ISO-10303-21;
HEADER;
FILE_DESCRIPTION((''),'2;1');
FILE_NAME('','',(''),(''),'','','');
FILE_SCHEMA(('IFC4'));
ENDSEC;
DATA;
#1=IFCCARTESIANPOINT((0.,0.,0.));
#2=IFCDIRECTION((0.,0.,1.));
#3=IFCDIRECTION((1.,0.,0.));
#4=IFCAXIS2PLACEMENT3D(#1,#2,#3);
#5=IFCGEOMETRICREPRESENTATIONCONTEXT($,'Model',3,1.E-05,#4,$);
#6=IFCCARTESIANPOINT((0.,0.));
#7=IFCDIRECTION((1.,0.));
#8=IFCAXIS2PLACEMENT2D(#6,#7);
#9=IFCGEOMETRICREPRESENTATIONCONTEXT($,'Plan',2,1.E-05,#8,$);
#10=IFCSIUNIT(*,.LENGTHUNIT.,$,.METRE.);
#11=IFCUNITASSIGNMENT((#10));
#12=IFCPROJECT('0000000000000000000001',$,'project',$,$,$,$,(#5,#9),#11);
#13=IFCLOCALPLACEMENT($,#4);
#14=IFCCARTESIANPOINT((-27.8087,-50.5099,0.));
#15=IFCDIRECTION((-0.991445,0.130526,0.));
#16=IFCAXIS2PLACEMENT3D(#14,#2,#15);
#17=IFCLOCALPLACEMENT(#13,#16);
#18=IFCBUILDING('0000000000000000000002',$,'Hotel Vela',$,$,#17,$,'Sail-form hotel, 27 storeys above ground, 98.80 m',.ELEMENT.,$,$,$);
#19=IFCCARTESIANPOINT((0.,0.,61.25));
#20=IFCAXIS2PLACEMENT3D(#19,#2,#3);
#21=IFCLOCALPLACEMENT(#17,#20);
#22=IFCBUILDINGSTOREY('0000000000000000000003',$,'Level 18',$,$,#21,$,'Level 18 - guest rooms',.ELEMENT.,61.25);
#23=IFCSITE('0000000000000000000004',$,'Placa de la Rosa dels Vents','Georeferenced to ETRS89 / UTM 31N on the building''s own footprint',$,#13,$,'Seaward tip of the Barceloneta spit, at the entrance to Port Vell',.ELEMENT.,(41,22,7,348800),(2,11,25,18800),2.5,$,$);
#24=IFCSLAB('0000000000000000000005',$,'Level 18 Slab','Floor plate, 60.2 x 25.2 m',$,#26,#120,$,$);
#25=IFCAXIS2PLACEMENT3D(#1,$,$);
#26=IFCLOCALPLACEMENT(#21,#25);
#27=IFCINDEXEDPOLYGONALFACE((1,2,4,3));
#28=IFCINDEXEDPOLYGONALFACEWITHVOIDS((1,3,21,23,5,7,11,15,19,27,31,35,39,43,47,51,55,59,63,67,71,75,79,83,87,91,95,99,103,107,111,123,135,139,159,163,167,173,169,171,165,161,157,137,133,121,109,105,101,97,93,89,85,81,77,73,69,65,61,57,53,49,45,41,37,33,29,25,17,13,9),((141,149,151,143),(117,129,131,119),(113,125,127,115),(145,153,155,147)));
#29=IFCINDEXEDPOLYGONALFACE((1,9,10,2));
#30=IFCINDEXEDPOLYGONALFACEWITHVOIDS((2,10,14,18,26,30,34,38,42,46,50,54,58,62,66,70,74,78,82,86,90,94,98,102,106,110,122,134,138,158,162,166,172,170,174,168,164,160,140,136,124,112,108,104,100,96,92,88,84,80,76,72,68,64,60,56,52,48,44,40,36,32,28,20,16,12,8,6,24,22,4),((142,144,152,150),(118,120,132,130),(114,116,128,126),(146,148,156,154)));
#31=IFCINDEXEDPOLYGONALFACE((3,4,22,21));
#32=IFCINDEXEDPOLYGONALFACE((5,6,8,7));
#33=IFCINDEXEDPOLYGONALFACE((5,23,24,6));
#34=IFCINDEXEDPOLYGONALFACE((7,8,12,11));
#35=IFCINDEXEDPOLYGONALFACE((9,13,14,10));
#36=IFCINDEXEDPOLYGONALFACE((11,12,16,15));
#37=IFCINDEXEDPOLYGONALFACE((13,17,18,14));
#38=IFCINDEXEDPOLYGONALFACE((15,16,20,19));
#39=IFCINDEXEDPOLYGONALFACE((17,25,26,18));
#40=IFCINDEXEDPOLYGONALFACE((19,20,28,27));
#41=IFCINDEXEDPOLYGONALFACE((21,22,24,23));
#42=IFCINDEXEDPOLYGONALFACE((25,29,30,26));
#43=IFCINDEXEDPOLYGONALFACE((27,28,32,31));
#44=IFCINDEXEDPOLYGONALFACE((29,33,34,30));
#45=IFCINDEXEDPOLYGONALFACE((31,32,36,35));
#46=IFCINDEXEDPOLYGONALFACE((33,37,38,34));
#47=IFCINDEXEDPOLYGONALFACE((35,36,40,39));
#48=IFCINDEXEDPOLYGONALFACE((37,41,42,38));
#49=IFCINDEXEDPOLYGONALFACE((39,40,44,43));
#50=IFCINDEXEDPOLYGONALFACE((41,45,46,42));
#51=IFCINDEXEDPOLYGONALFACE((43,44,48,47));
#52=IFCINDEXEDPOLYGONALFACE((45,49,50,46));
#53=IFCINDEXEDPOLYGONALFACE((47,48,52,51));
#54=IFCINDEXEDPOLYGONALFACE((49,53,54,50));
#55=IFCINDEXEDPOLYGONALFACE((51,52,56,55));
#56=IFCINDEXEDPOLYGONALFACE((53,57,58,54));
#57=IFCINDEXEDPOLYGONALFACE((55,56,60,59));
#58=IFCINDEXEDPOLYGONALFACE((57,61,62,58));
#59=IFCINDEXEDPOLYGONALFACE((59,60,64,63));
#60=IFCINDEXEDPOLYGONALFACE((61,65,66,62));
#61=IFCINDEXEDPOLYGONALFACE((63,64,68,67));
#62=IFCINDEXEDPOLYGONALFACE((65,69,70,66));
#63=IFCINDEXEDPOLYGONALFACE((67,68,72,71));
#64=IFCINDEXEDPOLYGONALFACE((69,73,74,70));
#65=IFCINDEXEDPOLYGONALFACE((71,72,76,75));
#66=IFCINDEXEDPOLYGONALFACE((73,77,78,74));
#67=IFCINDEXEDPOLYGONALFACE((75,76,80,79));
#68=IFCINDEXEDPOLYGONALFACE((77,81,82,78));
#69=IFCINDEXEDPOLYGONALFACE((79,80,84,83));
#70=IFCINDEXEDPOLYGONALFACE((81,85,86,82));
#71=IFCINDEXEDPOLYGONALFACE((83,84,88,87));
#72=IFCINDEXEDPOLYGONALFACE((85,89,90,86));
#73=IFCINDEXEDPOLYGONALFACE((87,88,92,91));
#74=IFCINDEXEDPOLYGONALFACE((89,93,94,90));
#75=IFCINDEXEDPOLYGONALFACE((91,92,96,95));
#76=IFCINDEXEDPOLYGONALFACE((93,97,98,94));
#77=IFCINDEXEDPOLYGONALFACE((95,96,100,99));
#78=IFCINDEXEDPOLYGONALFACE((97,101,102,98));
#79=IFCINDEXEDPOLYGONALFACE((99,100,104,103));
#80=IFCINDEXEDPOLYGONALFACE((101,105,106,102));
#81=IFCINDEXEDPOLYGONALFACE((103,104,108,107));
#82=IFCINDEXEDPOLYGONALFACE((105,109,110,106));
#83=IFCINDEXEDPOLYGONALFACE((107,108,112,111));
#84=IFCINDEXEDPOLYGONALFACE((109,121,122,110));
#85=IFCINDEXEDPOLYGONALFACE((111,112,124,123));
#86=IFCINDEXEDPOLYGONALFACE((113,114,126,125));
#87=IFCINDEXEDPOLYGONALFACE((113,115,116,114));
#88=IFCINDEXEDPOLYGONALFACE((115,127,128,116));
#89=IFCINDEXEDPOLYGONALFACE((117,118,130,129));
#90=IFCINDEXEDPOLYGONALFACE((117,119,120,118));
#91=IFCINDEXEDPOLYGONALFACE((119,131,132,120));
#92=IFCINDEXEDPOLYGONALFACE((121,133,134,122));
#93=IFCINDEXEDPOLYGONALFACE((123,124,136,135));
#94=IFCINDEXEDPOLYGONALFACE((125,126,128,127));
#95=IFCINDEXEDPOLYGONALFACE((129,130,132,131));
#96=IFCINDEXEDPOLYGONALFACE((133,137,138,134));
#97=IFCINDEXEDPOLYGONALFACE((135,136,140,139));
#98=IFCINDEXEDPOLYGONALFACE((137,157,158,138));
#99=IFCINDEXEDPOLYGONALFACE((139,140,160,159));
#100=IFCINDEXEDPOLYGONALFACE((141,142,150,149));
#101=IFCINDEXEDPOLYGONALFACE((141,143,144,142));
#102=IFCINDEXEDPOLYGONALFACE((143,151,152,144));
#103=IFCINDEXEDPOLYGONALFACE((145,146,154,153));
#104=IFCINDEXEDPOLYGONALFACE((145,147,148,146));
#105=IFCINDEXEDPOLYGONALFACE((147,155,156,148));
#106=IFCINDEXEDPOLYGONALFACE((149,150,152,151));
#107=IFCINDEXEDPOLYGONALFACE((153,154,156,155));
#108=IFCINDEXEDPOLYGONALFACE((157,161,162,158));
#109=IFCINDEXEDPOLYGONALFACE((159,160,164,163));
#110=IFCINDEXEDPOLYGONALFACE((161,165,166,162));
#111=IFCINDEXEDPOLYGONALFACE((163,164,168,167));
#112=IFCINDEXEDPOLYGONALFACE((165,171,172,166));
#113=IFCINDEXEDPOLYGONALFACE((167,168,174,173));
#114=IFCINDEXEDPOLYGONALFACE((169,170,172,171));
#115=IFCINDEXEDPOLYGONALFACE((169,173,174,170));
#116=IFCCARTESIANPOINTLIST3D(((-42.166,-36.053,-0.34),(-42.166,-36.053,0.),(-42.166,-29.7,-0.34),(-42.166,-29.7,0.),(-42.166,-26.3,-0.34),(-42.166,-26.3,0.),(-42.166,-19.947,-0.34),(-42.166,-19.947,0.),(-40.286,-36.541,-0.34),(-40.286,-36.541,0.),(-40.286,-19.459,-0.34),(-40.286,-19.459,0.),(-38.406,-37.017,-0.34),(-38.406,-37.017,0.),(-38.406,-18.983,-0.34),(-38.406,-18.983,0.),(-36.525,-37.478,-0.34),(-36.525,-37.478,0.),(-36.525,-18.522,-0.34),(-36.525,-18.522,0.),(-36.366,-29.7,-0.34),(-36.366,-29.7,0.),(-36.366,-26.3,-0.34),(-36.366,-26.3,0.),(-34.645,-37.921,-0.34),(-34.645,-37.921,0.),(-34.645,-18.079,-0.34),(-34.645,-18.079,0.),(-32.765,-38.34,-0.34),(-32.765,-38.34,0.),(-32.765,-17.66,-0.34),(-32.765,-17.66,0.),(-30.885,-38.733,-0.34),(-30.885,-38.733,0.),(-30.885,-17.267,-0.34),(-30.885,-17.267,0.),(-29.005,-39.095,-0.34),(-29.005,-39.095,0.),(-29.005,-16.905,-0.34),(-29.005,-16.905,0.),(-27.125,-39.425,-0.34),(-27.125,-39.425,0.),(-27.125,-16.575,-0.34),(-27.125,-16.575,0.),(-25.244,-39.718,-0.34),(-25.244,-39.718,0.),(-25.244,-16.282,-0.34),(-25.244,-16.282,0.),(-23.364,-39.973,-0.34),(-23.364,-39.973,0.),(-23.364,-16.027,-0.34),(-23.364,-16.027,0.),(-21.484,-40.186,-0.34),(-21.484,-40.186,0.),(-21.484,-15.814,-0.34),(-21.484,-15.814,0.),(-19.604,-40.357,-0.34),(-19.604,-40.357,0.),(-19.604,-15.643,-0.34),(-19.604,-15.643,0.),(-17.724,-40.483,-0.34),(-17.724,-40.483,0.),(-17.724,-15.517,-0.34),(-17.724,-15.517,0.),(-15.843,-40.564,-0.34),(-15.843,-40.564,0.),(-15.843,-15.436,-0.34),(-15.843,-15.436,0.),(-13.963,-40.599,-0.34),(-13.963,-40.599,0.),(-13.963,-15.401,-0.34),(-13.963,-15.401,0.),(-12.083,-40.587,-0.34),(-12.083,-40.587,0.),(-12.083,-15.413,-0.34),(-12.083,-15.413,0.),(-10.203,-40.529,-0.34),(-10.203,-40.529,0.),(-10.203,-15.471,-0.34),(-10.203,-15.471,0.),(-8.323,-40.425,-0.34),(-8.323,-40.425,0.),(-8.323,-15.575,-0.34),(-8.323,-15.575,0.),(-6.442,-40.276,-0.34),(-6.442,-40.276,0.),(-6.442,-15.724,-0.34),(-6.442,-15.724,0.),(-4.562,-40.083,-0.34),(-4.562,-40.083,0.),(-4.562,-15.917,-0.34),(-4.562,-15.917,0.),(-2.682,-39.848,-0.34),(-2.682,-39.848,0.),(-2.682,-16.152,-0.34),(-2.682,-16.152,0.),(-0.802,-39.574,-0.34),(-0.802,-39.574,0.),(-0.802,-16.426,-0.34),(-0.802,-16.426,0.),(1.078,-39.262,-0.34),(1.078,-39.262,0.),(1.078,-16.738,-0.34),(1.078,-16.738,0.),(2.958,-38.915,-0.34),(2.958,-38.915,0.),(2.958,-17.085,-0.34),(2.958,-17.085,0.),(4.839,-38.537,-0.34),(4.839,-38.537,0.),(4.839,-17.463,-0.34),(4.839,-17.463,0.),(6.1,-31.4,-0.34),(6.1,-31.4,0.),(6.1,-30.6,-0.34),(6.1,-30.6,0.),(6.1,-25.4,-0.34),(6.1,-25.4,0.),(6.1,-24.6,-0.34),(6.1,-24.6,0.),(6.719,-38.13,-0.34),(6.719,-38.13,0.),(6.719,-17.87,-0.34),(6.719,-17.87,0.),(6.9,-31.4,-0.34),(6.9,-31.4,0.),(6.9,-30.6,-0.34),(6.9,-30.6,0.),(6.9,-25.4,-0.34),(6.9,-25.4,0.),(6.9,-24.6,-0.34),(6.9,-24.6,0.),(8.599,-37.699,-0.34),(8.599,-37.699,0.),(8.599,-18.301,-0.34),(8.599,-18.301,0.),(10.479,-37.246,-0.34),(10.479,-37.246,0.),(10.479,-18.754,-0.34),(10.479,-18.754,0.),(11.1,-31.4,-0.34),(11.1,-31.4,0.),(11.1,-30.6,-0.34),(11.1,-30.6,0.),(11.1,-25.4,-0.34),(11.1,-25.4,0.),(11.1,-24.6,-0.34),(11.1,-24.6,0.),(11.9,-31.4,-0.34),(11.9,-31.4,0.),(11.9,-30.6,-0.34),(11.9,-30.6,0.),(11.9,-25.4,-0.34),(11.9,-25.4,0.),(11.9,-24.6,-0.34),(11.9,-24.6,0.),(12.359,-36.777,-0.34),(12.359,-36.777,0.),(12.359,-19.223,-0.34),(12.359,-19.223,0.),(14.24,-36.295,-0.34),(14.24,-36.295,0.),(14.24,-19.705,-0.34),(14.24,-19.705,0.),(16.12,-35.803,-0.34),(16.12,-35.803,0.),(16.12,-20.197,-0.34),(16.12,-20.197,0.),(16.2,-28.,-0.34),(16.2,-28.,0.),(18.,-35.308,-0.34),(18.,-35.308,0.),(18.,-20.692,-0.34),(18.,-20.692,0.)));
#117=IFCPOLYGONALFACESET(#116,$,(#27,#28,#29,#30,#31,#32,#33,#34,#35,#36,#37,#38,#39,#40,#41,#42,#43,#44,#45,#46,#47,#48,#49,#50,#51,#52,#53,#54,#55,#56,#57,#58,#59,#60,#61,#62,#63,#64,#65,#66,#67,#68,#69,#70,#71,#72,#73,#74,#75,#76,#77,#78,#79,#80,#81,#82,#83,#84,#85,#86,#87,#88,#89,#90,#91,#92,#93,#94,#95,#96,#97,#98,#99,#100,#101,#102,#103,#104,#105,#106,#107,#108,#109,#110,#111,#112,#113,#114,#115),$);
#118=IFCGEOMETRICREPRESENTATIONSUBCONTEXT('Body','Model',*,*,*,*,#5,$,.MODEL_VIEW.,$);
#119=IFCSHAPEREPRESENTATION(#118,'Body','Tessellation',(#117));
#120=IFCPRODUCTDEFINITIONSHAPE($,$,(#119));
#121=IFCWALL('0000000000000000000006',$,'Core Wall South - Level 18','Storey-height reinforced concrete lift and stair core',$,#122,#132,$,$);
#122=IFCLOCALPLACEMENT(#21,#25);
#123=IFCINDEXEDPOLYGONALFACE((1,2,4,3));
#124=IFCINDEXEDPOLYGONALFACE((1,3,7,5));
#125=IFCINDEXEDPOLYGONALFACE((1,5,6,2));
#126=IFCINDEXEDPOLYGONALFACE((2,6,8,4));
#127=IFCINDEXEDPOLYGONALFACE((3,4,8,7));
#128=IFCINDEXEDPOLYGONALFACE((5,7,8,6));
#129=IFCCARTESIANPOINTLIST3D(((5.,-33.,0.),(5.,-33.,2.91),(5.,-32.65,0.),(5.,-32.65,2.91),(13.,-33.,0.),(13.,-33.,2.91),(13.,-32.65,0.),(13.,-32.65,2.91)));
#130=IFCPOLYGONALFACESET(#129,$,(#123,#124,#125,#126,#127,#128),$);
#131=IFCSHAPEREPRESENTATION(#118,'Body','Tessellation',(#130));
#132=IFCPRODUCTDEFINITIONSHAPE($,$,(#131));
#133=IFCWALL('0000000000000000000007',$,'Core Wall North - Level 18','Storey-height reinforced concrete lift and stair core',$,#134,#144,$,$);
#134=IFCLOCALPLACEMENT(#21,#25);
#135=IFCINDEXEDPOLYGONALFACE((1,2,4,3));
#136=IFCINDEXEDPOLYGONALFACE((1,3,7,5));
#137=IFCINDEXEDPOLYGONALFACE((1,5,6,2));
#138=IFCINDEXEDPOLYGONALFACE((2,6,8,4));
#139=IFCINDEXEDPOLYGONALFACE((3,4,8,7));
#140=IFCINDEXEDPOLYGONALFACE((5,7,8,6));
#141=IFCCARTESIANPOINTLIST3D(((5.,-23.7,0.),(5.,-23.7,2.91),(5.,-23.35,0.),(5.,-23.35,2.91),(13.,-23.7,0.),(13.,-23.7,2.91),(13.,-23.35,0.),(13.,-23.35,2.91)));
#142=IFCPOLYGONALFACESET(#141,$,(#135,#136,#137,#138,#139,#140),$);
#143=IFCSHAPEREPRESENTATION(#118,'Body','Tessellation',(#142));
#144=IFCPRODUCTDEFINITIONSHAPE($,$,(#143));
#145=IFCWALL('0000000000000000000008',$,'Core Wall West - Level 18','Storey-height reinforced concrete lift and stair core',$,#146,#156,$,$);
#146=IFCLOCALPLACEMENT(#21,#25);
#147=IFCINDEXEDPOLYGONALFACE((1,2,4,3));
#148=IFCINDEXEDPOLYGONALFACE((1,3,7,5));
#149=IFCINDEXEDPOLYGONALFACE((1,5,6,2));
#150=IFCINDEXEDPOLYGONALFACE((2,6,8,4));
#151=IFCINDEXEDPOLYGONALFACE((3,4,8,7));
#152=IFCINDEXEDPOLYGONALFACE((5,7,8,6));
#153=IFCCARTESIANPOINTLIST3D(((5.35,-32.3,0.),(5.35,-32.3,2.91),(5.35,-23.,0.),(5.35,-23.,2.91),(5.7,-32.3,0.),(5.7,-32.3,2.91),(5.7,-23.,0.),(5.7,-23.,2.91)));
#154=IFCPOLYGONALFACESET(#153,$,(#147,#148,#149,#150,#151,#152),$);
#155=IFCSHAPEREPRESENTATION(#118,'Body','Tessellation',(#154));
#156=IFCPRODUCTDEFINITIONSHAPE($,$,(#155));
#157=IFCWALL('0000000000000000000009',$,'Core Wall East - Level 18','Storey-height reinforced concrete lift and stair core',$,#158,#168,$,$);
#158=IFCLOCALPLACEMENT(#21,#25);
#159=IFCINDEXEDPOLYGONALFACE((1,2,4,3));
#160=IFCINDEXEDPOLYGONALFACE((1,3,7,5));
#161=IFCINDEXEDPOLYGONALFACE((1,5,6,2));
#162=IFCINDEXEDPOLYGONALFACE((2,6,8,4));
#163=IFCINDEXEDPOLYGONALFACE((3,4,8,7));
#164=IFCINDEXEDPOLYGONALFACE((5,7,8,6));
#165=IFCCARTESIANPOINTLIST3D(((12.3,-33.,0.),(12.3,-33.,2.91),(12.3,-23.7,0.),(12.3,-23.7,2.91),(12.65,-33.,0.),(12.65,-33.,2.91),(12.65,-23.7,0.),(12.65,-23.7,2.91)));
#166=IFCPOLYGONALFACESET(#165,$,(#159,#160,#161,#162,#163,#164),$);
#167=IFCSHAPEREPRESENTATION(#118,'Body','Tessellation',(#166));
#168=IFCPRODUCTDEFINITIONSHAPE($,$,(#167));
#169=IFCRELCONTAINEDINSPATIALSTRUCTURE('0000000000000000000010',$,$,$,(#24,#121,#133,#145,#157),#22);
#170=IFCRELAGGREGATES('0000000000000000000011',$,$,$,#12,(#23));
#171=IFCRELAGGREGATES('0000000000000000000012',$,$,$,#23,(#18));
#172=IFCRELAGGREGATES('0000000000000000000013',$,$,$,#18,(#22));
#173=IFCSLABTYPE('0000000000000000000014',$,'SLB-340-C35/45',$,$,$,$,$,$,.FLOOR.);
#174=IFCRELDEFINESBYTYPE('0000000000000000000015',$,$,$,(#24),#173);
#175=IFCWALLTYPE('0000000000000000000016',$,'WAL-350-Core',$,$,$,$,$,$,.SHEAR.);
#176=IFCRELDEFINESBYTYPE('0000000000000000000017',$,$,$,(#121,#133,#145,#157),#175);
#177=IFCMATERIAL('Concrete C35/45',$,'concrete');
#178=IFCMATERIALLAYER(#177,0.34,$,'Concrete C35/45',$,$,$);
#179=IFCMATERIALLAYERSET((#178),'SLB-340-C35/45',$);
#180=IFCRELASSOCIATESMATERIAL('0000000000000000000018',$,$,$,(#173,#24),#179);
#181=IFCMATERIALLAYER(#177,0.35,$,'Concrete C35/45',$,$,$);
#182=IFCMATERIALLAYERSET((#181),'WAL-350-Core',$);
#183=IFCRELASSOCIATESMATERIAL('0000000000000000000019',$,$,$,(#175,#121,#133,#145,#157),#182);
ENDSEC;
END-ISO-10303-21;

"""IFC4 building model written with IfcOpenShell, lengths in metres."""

from ifc_helpers import new_model, si_unit, frame, origin_with_axes, origin_2d_with_axis, place, context, subcontext, project, spatial, line, indexed_curve, outline, extrude, material, layer, layer_set, layer_usage, type_object, element, save


model = new_model("IFC4")

# Units and contexts
model_context = context("Model", 3, precision=1e-05, world=origin_with_axes())
plan_context = context("Plan", 2, precision=1e-05, world=origin_2d_with_axis())
body_context = subcontext(model_context, "Body", "Model", "MODEL_VIEW")
ifc_project = project(units=[si_unit("LENGTHUNIT", "METRE")], contexts=[model_context, plan_context])

# Site, building, storey
site_placement = place(None, origin_with_axes())
site = spatial("IfcSite", under=ifc_project, at=site_placement, Name="Placa de la Rosa dels Vents", Description="Georeferenced to ETRS89 / UTM 31N on the building's own footprint", LongName="Seaward tip of the Barceloneta spit, at the entrance to Port Vell", CompositionType="ELEMENT", RefLatitude=(41, 22, 7, 348800), RefLongitude=(2, 11, 25, 18800), RefElevation=2.5)
building_placement = place(site_placement, frame((-27.8087, -50.5099, 0.0), z_axis=(0.0, 0.0, 1.0), x_axis=(-0.991445, 0.130526, 0.0)))
building = spatial("IfcBuilding", under=site, at=building_placement, Name="Hotel Vela", LongName="Sail-form hotel, 27 storeys above ground, 98.80 m", CompositionType="ELEMENT")
storey_placement = place(building_placement, frame((0.0, 0.0, 61.25), z_axis=(0.0, 0.0, 1.0), x_axis=(1.0, 0.0, 0.0)))
storey = spatial("IfcBuildingStorey", under=building, at=storey_placement, Name="Level 18", LongName="Level 18 - guest rooms", CompositionType="ELEMENT", Elevation=61.25)

# Shared definitions
ifc_material = material(Name="Concrete C35/45", Category="concrete")

# Slab, openings
ifc_layer_1 = layer(ifc_material, 0.34, Name="Concrete C35/45")
ifc_layer_set_1 = layer_set([ifc_layer_1], Name="SLB-340-C35/45")
ifc_layer_usage_1 = layer_usage(ifc_layer_set_1, "AXIS3", "POSITIVE", 0.0)
slab_type = type_object("IfcSlabType", Name="SLB-340-C35/45", PredefinedType="FLOOR", material=ifc_layer_set_1)
slab_placement = place(storey_placement, frame((0.0, 0.0, -0.34), z_axis=(0.0, 0.0, 1.0), x_axis=(1.0, 0.0, 0.0)))
slab = element("IfcSlab", 1, at=slab_placement, inside=storey, type_object=slab_type, material=ifc_layer_usage_1, Name="Level 18 Slab", Description="Floor plate, 60.2 x 25.2 m", context=body_context, shape_type="SweptSolid", body=[
    extrude(outline(indexed_curve([(-42.166, -36.053), (-40.286, -36.541), (-38.406, -37.017), (-36.525, -37.478), (-34.645, -37.921), (-32.765, -38.34), (-30.885, -38.733), (-29.005, -39.095), (-27.125, -39.425), (-25.244, -39.718), (-23.364, -39.973), (-21.484, -40.186), (-19.604, -40.357), (-17.724, -40.483), (-15.843, -40.564), (-13.963, -40.599), (-12.083, -40.587), (-10.203, -40.529), (-8.323, -40.425), (-6.442, -40.276), (-4.562, -40.083), (-2.682, -39.848), (-0.802, -39.574), (1.078, -39.262), (2.958, -38.915), (4.839, -38.537), (6.719, -38.13), (8.599, -37.699), (10.479, -37.246), (12.359, -36.777), (14.24, -36.295), (16.12, -35.803), (18.0, -35.308), (16.2, -28.0), (18.0, -20.692), (16.12, -20.197), (14.24, -19.705), (12.359, -19.223), (10.479, -18.754), (8.599, -18.301), (6.719, -17.87), (4.839, -17.463), (2.958, -17.085), (1.078, -16.738), (-0.802, -16.426), (-2.682, -16.152), (-4.562, -15.917), (-6.442, -15.724), (-8.323, -15.575), (-10.203, -15.471), (-12.083, -15.413), (-13.963, -15.401), (-15.843, -15.436), (-17.724, -15.517), (-19.604, -15.643), (-21.484, -15.814), (-23.364, -16.027), (-25.244, -16.282), (-27.125, -16.575), (-29.005, -16.905), (-30.885, -17.267), (-32.765, -17.66), (-34.645, -18.079), (-36.525, -18.522), (-38.406, -18.983), (-40.286, -19.459), (-42.166, -19.947), (-42.166, -26.3), (-36.366, -26.3), (-36.366, -29.7), (-42.166, -29.7)], segments=[line(1, 2, 3, 4, 5, 6, 7, 8, 9, 10, 11, 12, 13, 14, 15, 16, 17, 18, 19, 20, 21, 22, 23, 24, 25, 26, 27, 28, 29, 30, 31, 32, 33, 34, 35, 36, 37, 38, 39, 40, 41, 42, 43, 44, 45, 46, 47, 48, 49, 50, 51, 52, 53, 54, 55, 56, 57, 58, 59, 60, 61, 62, 63, 64, 65, 66, 67, 68, 69, 70, 71, 1)])), origin_with_axes(), (0.0, 0.0, 1.0), 0.34),
])
opening_1_placement = place(slab_placement, frame((6.1, -31.4, -0.05), z_axis=(0.0, 0.0, 1.0), x_axis=(1.0, 0.0, 0.0)))
element("IfcOpeningElement", 2, at=opening_1_placement, cuts=slab, PredefinedType="OPENING", context=body_context, shape_type="SweptSolid", body=[
    extrude(outline(indexed_curve([(0.0, 0.0), (0.8, 0.0), (0.8, 0.8), (0.0, 0.8)], segments=[line(1, 2, 3, 4, 1)])), origin_with_axes(), (0.0, 0.0, 1.0), 0.44),
])
opening_2_placement = place(slab_placement, frame((6.1, -25.4, -0.05), z_axis=(0.0, 0.0, 1.0), x_axis=(1.0, 0.0, 0.0)))
element("IfcOpeningElement", 3, at=opening_2_placement, cuts=slab, PredefinedType="OPENING", context=body_context, shape_type="SweptSolid", body=[
    extrude(outline(indexed_curve([(0.0, 0.0), (0.8, 0.0), (0.8, 0.8), (0.0, 0.8)], segments=[line(1, 2, 3, 4, 1)])), origin_with_axes(), (0.0, 0.0, 1.0), 0.44),
])
opening_3_placement = place(slab_placement, frame((11.1, -31.4, -0.05), z_axis=(0.0, 0.0, 1.0), x_axis=(1.0, 0.0, 0.0)))
element("IfcOpeningElement", 4, at=opening_3_placement, cuts=slab, PredefinedType="OPENING", context=body_context, shape_type="SweptSolid", body=[
    extrude(outline(indexed_curve([(0.0, 0.0), (0.8, 0.0), (0.8, 0.8), (0.0, 0.8)], segments=[line(1, 2, 3, 4, 1)])), origin_with_axes(), (0.0, 0.0, 1.0), 0.44),
])
opening_4_placement = place(slab_placement, frame((11.1, -25.4, -0.05), z_axis=(0.0, 0.0, 1.0), x_axis=(1.0, 0.0, 0.0)))
element("IfcOpeningElement", 5, at=opening_4_placement, cuts=slab, PredefinedType="OPENING", context=body_context, shape_type="SweptSolid", body=[
    extrude(outline(indexed_curve([(0.0, 0.0), (0.8, 0.0), (0.8, 0.8), (0.0, 0.8)], segments=[line(1, 2, 3, 4, 1)])), origin_with_axes(), (0.0, 0.0, 1.0), 0.44),
])

# Walls
ifc_layer_2 = layer(ifc_material, 0.35, Name="Concrete C35/45")
ifc_layer_set_2 = layer_set([ifc_layer_2], Name="WAL-350-Core")
ifc_layer_usage_2 = layer_usage(ifc_layer_set_2, "AXIS2", "POSITIVE", 0.0)
wall_type = type_object("IfcWallType", Name="WAL-350-Core", PredefinedType="SHEAR", material=ifc_layer_set_2)
wall_1_placement = place(storey_placement, frame((5.0, -33.0, 0.0), z_axis=(0.0, 0.0, 1.0), x_axis=(1.0, 0.0, 0.0)))
element("IfcWall", 6, at=wall_1_placement, inside=storey, type_object=wall_type, material=ifc_layer_usage_2, Name="Core Wall South - Level 18", Description="Storey-height reinforced concrete lift and stair core", context=body_context, shape_type="SweptSolid", body=[
    extrude(outline(indexed_curve([(0.0, 0.0), (8.0, 0.0), (8.0, 0.35), (0.0, 0.35)], segments=[line(1, 2, 3, 4, 1)])), origin_with_axes(), (0.0, 0.0, 1.0), 2.91),
])
ifc_layer_usage_3 = layer_usage(ifc_layer_set_2, "AXIS2", "POSITIVE", 0.0)
wall_2_placement = place(storey_placement, frame((13.0, -23.35, 0.0), z_axis=(0.0, 0.0, 1.0), x_axis=(-1.0, 0.0, 0.0)))
element("IfcWall", 7, at=wall_2_placement, inside=storey, type_object=wall_type, material=ifc_layer_usage_3, Name="Core Wall North - Level 18", Description="Storey-height reinforced concrete lift and stair core", context=body_context, shape_type="SweptSolid", body=[
    extrude(outline(indexed_curve([(0.0, 0.0), (8.0, 0.0), (8.0, 0.35), (0.0, 0.35)], segments=[line(1, 2, 3, 4, 1)])), origin_with_axes(), (0.0, 0.0, 1.0), 2.91),
])
ifc_layer_usage_4 = layer_usage(ifc_layer_set_2, "AXIS2", "POSITIVE", 0.0)
wall_3_placement = place(storey_placement, frame((5.35, -23.0, 0.0), z_axis=(0.0, 0.0, 1.0), x_axis=(0.0, -1.0, 0.0)))
element("IfcWall", 8, at=wall_3_placement, inside=storey, type_object=wall_type, material=ifc_layer_usage_4, Name="Core Wall West - Level 18", Description="Storey-height reinforced concrete lift and stair core", context=body_context, shape_type="SweptSolid", body=[
    extrude(outline(indexed_curve([(0.0, 0.0), (9.3, 0.0), (9.3, 0.35), (0.0, 0.35)], segments=[line(1, 2, 3, 4, 1)])), origin_with_axes(), (0.0, 0.0, 1.0), 2.91),
])
ifc_layer_usage_5 = layer_usage(ifc_layer_set_2, "AXIS2", "POSITIVE", 0.0)
wall_4_placement = place(storey_placement, frame((12.65, -33.0, 0.0), z_axis=(0.0, 0.0, 1.0), x_axis=(0.0, 1.0, 0.0)))
element("IfcWall", 9, at=wall_4_placement, inside=storey, type_object=wall_type, material=ifc_layer_usage_5, Name="Core Wall East - Level 18", Description="Storey-height reinforced concrete lift and stair core", context=body_context, shape_type="SweptSolid", body=[
    extrude(outline(indexed_curve([(0.0, 0.0), (9.3, 0.0), (9.3, 0.35), (0.0, 0.35)], segments=[line(1, 2, 3, 4, 1)])), origin_with_axes(), (0.0, 0.0, 1.0), 2.91),
])

save(model, "model.ifc")
